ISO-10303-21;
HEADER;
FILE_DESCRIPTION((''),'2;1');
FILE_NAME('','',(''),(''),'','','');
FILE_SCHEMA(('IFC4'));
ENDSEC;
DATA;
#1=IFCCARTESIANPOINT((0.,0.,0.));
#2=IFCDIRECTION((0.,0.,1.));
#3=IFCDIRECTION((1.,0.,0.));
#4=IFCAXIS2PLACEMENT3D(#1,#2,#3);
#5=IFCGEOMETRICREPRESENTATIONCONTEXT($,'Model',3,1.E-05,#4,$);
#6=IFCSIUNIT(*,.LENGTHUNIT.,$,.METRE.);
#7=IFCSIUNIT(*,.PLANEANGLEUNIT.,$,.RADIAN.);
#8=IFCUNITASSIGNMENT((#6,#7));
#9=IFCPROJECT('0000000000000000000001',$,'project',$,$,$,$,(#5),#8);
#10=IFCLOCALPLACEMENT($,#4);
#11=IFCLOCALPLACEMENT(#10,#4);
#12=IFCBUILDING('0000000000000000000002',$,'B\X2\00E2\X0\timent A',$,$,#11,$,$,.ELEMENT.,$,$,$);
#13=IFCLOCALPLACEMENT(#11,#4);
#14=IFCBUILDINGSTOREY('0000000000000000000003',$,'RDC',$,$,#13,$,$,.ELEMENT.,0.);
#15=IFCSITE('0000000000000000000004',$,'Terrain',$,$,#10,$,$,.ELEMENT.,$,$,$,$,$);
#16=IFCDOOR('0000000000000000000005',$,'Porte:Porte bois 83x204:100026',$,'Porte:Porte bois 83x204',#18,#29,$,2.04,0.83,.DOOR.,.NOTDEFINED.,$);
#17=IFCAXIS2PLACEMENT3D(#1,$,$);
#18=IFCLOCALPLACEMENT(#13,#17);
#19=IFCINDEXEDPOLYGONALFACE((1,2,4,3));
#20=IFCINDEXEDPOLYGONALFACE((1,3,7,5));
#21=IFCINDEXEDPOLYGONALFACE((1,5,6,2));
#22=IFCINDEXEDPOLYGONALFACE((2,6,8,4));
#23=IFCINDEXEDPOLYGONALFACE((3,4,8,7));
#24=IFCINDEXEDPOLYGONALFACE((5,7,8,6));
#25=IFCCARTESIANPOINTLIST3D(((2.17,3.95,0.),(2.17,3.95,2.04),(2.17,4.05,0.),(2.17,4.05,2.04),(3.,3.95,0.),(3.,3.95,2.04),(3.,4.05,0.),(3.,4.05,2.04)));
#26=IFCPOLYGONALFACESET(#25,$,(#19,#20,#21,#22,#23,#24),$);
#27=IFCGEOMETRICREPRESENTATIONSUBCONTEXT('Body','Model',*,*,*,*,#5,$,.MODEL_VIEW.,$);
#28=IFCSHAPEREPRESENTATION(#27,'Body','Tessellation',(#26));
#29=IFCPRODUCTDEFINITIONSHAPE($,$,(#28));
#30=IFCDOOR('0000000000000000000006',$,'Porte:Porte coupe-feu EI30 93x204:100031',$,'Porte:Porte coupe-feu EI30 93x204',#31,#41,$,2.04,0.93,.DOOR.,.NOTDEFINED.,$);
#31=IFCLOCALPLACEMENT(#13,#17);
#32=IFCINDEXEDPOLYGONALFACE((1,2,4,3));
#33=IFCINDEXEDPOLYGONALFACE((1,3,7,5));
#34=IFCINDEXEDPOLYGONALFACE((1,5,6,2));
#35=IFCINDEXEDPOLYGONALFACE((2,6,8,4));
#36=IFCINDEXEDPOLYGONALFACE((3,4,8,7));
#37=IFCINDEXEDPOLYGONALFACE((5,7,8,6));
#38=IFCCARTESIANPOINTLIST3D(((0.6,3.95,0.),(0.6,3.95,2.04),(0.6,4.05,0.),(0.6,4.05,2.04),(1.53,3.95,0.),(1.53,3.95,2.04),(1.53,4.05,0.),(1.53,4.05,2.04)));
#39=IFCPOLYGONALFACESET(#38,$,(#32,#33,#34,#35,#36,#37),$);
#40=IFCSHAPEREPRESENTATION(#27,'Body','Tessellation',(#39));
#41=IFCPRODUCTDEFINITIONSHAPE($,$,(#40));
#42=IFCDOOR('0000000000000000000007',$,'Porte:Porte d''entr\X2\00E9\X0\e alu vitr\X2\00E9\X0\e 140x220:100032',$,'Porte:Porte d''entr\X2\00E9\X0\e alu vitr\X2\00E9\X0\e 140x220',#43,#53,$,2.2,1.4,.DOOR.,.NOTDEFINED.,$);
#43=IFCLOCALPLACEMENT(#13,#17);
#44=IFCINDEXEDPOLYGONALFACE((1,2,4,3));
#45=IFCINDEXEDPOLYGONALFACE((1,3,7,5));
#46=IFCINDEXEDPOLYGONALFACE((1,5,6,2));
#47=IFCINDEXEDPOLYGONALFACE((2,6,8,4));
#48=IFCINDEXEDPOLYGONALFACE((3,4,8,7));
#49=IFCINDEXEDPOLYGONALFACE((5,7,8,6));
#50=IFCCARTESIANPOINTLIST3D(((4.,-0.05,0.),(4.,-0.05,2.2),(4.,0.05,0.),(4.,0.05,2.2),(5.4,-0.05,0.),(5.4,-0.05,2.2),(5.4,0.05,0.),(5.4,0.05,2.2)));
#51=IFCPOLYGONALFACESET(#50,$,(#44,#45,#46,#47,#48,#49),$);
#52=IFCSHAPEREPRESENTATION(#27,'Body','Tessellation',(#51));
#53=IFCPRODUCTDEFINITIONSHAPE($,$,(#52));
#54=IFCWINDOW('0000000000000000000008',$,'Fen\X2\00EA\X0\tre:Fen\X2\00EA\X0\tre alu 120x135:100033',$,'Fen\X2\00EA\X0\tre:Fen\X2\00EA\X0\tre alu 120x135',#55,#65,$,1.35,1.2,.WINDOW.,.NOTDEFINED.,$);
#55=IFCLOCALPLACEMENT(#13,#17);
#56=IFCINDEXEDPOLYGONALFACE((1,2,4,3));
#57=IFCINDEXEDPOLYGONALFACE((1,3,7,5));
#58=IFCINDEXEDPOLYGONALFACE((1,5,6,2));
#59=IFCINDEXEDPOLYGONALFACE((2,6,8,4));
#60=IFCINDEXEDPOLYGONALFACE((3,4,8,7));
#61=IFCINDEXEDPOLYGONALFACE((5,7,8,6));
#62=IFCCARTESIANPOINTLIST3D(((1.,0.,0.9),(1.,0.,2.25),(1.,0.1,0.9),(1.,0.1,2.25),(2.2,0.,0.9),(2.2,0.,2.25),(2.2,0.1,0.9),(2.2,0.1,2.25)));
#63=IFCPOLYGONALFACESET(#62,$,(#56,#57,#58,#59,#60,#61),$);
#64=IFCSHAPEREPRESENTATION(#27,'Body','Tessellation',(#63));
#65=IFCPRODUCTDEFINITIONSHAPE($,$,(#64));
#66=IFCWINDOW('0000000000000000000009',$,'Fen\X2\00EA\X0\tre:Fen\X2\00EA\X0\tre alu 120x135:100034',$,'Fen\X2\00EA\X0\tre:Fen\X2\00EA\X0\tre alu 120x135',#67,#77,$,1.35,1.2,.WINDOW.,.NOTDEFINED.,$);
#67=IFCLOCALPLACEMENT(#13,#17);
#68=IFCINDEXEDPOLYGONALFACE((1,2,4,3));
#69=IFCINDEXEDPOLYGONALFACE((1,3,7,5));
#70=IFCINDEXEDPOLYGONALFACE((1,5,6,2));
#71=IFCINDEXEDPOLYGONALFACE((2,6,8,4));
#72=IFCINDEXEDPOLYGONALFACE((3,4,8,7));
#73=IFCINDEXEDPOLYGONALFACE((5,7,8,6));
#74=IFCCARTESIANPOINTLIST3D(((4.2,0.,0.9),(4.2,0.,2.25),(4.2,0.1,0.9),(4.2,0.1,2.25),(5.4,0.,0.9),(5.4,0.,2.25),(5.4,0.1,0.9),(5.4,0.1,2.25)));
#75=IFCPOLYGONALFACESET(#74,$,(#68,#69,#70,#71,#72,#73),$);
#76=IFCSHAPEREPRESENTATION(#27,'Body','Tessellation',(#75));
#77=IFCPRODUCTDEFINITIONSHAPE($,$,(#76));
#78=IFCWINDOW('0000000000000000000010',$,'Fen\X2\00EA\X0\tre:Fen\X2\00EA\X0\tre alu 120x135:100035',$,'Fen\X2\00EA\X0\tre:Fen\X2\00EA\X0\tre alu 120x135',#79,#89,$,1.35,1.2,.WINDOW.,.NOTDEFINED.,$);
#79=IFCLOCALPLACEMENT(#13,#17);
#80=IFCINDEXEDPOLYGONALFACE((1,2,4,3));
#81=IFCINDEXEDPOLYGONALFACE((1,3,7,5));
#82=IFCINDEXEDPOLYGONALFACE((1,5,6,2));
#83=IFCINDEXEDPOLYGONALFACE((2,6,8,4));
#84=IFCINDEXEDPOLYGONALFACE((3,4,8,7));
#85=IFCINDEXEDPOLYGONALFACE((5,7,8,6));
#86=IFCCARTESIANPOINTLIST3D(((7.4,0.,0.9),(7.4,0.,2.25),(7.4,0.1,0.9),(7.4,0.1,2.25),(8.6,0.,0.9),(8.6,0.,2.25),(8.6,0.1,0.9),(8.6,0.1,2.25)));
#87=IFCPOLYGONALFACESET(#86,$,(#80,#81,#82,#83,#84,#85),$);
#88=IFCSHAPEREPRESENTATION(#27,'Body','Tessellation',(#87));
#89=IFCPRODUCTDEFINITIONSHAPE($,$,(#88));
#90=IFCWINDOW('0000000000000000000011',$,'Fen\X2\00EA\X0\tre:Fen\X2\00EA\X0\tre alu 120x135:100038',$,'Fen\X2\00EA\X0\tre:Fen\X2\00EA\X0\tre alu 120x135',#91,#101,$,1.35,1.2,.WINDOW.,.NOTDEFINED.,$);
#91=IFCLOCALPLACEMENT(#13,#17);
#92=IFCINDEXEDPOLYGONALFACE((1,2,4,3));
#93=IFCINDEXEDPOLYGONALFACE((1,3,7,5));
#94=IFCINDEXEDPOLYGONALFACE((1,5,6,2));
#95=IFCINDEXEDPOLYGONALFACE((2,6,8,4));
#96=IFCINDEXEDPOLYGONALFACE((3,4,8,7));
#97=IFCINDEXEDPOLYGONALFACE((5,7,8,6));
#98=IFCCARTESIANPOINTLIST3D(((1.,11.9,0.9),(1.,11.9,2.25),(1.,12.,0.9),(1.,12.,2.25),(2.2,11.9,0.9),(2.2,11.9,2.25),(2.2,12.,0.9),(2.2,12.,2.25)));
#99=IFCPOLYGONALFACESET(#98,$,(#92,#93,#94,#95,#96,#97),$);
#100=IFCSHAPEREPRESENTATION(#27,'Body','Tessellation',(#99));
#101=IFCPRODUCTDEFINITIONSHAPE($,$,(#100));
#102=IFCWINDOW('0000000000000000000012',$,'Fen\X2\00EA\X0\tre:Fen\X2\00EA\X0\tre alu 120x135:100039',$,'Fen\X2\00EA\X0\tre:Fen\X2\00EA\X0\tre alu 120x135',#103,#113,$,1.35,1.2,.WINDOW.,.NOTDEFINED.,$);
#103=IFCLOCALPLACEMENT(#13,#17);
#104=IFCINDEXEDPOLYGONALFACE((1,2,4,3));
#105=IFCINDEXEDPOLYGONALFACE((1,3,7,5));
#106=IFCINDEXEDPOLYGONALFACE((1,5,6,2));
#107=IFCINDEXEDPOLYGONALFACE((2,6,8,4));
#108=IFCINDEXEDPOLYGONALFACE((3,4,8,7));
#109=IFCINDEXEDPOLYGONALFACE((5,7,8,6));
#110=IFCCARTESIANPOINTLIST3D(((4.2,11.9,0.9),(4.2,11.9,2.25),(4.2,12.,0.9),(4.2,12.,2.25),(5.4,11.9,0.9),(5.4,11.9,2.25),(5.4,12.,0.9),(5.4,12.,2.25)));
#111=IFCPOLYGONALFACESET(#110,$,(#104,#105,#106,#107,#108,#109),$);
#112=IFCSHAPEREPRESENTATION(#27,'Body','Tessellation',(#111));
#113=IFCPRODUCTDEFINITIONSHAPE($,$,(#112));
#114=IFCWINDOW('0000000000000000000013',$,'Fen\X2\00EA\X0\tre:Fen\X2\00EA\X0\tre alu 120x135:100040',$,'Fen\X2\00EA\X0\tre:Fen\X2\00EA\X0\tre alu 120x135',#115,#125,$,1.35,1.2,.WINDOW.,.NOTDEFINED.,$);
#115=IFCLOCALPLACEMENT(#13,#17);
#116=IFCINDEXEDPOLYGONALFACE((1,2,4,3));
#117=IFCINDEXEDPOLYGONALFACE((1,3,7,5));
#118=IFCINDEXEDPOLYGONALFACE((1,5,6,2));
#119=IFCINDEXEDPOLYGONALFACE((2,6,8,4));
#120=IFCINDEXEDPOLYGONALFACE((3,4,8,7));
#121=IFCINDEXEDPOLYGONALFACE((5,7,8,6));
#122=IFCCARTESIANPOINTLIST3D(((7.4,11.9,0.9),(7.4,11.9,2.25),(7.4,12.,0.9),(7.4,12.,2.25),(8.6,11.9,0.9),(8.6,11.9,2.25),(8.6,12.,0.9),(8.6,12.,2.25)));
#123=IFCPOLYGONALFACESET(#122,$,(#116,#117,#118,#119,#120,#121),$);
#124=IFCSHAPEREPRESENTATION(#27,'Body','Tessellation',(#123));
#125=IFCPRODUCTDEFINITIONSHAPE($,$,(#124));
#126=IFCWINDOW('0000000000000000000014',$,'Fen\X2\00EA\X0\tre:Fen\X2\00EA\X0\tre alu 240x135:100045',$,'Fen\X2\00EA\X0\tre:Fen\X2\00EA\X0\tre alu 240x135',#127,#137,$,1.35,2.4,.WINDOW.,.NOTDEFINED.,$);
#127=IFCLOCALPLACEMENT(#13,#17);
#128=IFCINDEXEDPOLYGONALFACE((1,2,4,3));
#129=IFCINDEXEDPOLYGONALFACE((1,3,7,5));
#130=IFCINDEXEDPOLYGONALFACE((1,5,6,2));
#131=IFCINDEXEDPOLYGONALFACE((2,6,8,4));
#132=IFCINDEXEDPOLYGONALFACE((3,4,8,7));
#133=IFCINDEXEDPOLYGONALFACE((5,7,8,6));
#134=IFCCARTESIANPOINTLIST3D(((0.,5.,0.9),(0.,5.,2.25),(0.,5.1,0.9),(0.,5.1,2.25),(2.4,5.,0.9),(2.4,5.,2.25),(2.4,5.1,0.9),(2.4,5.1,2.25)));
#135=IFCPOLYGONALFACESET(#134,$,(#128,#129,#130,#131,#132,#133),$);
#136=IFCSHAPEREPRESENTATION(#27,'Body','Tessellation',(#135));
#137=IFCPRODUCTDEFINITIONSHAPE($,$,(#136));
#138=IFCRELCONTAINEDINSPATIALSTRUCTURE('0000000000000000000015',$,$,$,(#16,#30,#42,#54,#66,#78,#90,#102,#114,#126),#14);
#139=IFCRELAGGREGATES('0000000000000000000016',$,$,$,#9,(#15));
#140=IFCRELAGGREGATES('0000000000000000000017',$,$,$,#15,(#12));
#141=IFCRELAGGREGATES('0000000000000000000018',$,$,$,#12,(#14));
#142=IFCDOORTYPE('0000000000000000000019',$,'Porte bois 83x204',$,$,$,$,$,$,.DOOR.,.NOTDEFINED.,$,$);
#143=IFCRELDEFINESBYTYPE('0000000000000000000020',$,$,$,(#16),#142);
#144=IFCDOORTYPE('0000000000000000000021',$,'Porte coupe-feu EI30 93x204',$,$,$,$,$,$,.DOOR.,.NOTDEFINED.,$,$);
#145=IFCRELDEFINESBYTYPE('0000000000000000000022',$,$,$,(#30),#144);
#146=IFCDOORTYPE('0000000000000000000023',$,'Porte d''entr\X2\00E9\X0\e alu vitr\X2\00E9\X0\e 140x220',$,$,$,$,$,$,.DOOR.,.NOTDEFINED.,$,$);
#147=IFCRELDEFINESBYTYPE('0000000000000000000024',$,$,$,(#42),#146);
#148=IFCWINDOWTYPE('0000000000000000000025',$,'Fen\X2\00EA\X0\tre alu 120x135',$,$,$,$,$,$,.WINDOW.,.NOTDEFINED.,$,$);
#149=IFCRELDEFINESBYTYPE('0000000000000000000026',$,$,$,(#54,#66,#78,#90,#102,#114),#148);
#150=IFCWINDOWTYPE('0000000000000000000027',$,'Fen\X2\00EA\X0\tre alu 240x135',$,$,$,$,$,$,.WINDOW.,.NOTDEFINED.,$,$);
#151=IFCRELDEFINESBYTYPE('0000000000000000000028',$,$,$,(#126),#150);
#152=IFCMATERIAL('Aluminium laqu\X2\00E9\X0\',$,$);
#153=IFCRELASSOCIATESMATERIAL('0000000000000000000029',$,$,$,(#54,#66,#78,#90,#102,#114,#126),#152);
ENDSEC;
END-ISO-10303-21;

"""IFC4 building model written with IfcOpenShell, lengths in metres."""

from ifc_helpers import new_model, si_unit, frame, frame_2d, origin_with_axes, place, context, subcontext, project, spatial, rectangle, extrude, material, type_object, element, save


model = new_model("IFC4")

# Units and contexts
model_context = context("Model", 3, precision=1e-05, world=origin_with_axes())
body_context = subcontext(model_context, "Body", "Model", "MODEL_VIEW")
ifc_project = project(units=[si_unit("LENGTHUNIT", "METRE"), si_unit("PLANEANGLEUNIT", "RADIAN")], contexts=[model_context])

# Site, building, storey
site_placement = place(None, origin_with_axes())
site = spatial("IfcSite", under=ifc_project, at=site_placement, Name="Terrain", CompositionType="ELEMENT")
building_placement = place(site_placement, origin_with_axes())
building = spatial("IfcBuilding", under=site, at=building_placement, Name="Bâtiment A", CompositionType="ELEMENT")
storey_placement = place(building_placement, origin_with_axes())
storey = spatial("IfcBuildingStorey", under=building, at=storey_placement, Name="RDC", CompositionType="ELEMENT", Elevation=0.0)

# Doors
door_type_1 = type_object("IfcDoorType", Name="Porte bois 83x204", OperationType="NOTDEFINED", PredefinedType="DOOR")
for number, where, z_axis, x_axis, name in (
    (1, (2.17, 3.95, 0.0), (0.0, 0.0, 1.0), (1.0, 0.0, 0.0), "Porte:Porte bois 83x204:100026"),
):
    element("IfcDoor", number, at=place(storey_placement, frame(where, z_axis=z_axis, x_axis=x_axis)), inside=storey, type_object=door_type_1, Name=name, ObjectType="Porte:Porte bois 83x204", OperationType="NOTDEFINED", OverallHeight=2.04, OverallWidth=0.83, PredefinedType="DOOR", context=body_context, shape_type="SweptSolid", body=[
        extrude(rectangle(XDim=0.83, YDim=0.1, at=frame_2d((0.415, 0.05))), origin_with_axes(), (0.0, 0.0, 1.0), 2.04),
    ])
door_type_2 = type_object("IfcDoorType", Name="Porte coupe-feu EI30 93x204", OperationType="NOTDEFINED", PredefinedType="DOOR")
door_1_placement = place(storey_placement, frame((0.6, 3.95, 0.0), z_axis=(0.0, 0.0, 1.0), x_axis=(1.0, 0.0, 0.0)))
element("IfcDoor", 2, at=door_1_placement, inside=storey, type_object=door_type_2, Name="Porte:Porte coupe-feu EI30 93x204:100031", ObjectType="Porte:Porte coupe-feu EI30 93x204", OperationType="NOTDEFINED", OverallHeight=2.04, OverallWidth=0.93, PredefinedType="DOOR", context=body_context, shape_type="SweptSolid", body=[
    extrude(rectangle(XDim=0.93, YDim=0.1, at=frame_2d((0.465, 0.05))), origin_with_axes(), (0.0, 0.0, 1.0), 2.04),
])
door_type_3 = type_object("IfcDoorType", Name="Porte d'entrée alu vitrée 140x220", OperationType="NOTDEFINED", PredefinedType="DOOR")
door_2_placement = place(storey_placement, frame((4.0, -0.05, 0.0), z_axis=(0.0, 0.0, 1.0), x_axis=(1.0, 0.0, 0.0)))
element("IfcDoor", 3, at=door_2_placement, inside=storey, type_object=door_type_3, Name="Porte:Porte d'entrée alu vitrée 140x220:100032", ObjectType="Porte:Porte d'entrée alu vitrée 140x220", OperationType="NOTDEFINED", OverallHeight=2.2, OverallWidth=1.4, PredefinedType="DOOR", context=body_context, shape_type="SweptSolid", body=[
    extrude(rectangle(XDim=1.4, YDim=0.1, at=frame_2d((0.7, 0.05))), origin_with_axes(), (0.0, 0.0, 1.0), 2.2),
])

# Windows
ifc_material_1 = material(Name="Aluminium laqué")
window_type_1 = type_object("IfcWindowType", Name="Fenêtre alu 120x135", PartitioningType="NOTDEFINED", PredefinedType="WINDOW")
for number, where, z_axis, x_axis, name in (
    (4, (1.0, 0.0, 0.9), (0.0, 0.0, 1.0), (1.0, 0.0, 0.0), "Fenêtre:Fenêtre alu 120x135:100033"),
    (5, (4.2, 0.0, 0.9), (0.0, 0.0, 1.0), (1.0, 0.0, 0.0), "Fenêtre:Fenêtre alu 120x135:100034"),
    (6, (7.4, 0.0, 0.9), (0.0, 0.0, 1.0), (1.0, 0.0, 0.0), "Fenêtre:Fenêtre alu 120x135:100035"),
    (7, (1.0, 11.9, 0.9), (0.0, 0.0, 1.0), (1.0, 0.0, 0.0), "Fenêtre:Fenêtre alu 120x135:100038"),
    (8, (4.2, 11.9, 0.9), (0.0, 0.0, 1.0), (1.0, 0.0, 0.0), "Fenêtre:Fenêtre alu 120x135:100039"),
    (9, (7.4, 11.9, 0.9), (0.0, 0.0, 1.0), (1.0, 0.0, 0.0), "Fenêtre:Fenêtre alu 120x135:100040"),
):
    element("IfcWindow", number, at=place(storey_placement, frame(where, z_axis=z_axis, x_axis=x_axis)), inside=storey, type_object=window_type_1, material=ifc_material_1, Name=name, ObjectType="Fenêtre:Fenêtre alu 120x135", OverallHeight=1.35, OverallWidth=1.2, PartitioningType="NOTDEFINED", PredefinedType="WINDOW", context=body_context, shape_type="SweptSolid", body=[
        extrude(rectangle(XDim=1.2, YDim=0.1, at=frame_2d((0.6, 0.05))), origin_with_axes(), (0.0, 0.0, 1.0), 1.35),
    ])
window_type_2 = type_object("IfcWindowType", Name="Fenêtre alu 240x135", PartitioningType="NOTDEFINED", PredefinedType="WINDOW")
window_placement = place(storey_placement, frame((0.0, 5.0, 0.9), z_axis=(0.0, 0.0, 1.0), x_axis=(1.0, 0.0, 0.0)))
element("IfcWindow", 10, at=window_placement, inside=storey, type_object=window_type_2, material=ifc_material_1, Name="Fenêtre:Fenêtre alu 240x135:100045", ObjectType="Fenêtre:Fenêtre alu 240x135", OverallHeight=1.35, OverallWidth=2.4, PartitioningType="NOTDEFINED", PredefinedType="WINDOW", context=body_context, shape_type="SweptSolid", body=[
    extrude(rectangle(XDim=2.4, YDim=0.1, at=frame_2d((1.2, 0.05))), origin_with_axes(), (0.0, 0.0, 1.0), 1.35),
])

save(model, "model.ifc")
